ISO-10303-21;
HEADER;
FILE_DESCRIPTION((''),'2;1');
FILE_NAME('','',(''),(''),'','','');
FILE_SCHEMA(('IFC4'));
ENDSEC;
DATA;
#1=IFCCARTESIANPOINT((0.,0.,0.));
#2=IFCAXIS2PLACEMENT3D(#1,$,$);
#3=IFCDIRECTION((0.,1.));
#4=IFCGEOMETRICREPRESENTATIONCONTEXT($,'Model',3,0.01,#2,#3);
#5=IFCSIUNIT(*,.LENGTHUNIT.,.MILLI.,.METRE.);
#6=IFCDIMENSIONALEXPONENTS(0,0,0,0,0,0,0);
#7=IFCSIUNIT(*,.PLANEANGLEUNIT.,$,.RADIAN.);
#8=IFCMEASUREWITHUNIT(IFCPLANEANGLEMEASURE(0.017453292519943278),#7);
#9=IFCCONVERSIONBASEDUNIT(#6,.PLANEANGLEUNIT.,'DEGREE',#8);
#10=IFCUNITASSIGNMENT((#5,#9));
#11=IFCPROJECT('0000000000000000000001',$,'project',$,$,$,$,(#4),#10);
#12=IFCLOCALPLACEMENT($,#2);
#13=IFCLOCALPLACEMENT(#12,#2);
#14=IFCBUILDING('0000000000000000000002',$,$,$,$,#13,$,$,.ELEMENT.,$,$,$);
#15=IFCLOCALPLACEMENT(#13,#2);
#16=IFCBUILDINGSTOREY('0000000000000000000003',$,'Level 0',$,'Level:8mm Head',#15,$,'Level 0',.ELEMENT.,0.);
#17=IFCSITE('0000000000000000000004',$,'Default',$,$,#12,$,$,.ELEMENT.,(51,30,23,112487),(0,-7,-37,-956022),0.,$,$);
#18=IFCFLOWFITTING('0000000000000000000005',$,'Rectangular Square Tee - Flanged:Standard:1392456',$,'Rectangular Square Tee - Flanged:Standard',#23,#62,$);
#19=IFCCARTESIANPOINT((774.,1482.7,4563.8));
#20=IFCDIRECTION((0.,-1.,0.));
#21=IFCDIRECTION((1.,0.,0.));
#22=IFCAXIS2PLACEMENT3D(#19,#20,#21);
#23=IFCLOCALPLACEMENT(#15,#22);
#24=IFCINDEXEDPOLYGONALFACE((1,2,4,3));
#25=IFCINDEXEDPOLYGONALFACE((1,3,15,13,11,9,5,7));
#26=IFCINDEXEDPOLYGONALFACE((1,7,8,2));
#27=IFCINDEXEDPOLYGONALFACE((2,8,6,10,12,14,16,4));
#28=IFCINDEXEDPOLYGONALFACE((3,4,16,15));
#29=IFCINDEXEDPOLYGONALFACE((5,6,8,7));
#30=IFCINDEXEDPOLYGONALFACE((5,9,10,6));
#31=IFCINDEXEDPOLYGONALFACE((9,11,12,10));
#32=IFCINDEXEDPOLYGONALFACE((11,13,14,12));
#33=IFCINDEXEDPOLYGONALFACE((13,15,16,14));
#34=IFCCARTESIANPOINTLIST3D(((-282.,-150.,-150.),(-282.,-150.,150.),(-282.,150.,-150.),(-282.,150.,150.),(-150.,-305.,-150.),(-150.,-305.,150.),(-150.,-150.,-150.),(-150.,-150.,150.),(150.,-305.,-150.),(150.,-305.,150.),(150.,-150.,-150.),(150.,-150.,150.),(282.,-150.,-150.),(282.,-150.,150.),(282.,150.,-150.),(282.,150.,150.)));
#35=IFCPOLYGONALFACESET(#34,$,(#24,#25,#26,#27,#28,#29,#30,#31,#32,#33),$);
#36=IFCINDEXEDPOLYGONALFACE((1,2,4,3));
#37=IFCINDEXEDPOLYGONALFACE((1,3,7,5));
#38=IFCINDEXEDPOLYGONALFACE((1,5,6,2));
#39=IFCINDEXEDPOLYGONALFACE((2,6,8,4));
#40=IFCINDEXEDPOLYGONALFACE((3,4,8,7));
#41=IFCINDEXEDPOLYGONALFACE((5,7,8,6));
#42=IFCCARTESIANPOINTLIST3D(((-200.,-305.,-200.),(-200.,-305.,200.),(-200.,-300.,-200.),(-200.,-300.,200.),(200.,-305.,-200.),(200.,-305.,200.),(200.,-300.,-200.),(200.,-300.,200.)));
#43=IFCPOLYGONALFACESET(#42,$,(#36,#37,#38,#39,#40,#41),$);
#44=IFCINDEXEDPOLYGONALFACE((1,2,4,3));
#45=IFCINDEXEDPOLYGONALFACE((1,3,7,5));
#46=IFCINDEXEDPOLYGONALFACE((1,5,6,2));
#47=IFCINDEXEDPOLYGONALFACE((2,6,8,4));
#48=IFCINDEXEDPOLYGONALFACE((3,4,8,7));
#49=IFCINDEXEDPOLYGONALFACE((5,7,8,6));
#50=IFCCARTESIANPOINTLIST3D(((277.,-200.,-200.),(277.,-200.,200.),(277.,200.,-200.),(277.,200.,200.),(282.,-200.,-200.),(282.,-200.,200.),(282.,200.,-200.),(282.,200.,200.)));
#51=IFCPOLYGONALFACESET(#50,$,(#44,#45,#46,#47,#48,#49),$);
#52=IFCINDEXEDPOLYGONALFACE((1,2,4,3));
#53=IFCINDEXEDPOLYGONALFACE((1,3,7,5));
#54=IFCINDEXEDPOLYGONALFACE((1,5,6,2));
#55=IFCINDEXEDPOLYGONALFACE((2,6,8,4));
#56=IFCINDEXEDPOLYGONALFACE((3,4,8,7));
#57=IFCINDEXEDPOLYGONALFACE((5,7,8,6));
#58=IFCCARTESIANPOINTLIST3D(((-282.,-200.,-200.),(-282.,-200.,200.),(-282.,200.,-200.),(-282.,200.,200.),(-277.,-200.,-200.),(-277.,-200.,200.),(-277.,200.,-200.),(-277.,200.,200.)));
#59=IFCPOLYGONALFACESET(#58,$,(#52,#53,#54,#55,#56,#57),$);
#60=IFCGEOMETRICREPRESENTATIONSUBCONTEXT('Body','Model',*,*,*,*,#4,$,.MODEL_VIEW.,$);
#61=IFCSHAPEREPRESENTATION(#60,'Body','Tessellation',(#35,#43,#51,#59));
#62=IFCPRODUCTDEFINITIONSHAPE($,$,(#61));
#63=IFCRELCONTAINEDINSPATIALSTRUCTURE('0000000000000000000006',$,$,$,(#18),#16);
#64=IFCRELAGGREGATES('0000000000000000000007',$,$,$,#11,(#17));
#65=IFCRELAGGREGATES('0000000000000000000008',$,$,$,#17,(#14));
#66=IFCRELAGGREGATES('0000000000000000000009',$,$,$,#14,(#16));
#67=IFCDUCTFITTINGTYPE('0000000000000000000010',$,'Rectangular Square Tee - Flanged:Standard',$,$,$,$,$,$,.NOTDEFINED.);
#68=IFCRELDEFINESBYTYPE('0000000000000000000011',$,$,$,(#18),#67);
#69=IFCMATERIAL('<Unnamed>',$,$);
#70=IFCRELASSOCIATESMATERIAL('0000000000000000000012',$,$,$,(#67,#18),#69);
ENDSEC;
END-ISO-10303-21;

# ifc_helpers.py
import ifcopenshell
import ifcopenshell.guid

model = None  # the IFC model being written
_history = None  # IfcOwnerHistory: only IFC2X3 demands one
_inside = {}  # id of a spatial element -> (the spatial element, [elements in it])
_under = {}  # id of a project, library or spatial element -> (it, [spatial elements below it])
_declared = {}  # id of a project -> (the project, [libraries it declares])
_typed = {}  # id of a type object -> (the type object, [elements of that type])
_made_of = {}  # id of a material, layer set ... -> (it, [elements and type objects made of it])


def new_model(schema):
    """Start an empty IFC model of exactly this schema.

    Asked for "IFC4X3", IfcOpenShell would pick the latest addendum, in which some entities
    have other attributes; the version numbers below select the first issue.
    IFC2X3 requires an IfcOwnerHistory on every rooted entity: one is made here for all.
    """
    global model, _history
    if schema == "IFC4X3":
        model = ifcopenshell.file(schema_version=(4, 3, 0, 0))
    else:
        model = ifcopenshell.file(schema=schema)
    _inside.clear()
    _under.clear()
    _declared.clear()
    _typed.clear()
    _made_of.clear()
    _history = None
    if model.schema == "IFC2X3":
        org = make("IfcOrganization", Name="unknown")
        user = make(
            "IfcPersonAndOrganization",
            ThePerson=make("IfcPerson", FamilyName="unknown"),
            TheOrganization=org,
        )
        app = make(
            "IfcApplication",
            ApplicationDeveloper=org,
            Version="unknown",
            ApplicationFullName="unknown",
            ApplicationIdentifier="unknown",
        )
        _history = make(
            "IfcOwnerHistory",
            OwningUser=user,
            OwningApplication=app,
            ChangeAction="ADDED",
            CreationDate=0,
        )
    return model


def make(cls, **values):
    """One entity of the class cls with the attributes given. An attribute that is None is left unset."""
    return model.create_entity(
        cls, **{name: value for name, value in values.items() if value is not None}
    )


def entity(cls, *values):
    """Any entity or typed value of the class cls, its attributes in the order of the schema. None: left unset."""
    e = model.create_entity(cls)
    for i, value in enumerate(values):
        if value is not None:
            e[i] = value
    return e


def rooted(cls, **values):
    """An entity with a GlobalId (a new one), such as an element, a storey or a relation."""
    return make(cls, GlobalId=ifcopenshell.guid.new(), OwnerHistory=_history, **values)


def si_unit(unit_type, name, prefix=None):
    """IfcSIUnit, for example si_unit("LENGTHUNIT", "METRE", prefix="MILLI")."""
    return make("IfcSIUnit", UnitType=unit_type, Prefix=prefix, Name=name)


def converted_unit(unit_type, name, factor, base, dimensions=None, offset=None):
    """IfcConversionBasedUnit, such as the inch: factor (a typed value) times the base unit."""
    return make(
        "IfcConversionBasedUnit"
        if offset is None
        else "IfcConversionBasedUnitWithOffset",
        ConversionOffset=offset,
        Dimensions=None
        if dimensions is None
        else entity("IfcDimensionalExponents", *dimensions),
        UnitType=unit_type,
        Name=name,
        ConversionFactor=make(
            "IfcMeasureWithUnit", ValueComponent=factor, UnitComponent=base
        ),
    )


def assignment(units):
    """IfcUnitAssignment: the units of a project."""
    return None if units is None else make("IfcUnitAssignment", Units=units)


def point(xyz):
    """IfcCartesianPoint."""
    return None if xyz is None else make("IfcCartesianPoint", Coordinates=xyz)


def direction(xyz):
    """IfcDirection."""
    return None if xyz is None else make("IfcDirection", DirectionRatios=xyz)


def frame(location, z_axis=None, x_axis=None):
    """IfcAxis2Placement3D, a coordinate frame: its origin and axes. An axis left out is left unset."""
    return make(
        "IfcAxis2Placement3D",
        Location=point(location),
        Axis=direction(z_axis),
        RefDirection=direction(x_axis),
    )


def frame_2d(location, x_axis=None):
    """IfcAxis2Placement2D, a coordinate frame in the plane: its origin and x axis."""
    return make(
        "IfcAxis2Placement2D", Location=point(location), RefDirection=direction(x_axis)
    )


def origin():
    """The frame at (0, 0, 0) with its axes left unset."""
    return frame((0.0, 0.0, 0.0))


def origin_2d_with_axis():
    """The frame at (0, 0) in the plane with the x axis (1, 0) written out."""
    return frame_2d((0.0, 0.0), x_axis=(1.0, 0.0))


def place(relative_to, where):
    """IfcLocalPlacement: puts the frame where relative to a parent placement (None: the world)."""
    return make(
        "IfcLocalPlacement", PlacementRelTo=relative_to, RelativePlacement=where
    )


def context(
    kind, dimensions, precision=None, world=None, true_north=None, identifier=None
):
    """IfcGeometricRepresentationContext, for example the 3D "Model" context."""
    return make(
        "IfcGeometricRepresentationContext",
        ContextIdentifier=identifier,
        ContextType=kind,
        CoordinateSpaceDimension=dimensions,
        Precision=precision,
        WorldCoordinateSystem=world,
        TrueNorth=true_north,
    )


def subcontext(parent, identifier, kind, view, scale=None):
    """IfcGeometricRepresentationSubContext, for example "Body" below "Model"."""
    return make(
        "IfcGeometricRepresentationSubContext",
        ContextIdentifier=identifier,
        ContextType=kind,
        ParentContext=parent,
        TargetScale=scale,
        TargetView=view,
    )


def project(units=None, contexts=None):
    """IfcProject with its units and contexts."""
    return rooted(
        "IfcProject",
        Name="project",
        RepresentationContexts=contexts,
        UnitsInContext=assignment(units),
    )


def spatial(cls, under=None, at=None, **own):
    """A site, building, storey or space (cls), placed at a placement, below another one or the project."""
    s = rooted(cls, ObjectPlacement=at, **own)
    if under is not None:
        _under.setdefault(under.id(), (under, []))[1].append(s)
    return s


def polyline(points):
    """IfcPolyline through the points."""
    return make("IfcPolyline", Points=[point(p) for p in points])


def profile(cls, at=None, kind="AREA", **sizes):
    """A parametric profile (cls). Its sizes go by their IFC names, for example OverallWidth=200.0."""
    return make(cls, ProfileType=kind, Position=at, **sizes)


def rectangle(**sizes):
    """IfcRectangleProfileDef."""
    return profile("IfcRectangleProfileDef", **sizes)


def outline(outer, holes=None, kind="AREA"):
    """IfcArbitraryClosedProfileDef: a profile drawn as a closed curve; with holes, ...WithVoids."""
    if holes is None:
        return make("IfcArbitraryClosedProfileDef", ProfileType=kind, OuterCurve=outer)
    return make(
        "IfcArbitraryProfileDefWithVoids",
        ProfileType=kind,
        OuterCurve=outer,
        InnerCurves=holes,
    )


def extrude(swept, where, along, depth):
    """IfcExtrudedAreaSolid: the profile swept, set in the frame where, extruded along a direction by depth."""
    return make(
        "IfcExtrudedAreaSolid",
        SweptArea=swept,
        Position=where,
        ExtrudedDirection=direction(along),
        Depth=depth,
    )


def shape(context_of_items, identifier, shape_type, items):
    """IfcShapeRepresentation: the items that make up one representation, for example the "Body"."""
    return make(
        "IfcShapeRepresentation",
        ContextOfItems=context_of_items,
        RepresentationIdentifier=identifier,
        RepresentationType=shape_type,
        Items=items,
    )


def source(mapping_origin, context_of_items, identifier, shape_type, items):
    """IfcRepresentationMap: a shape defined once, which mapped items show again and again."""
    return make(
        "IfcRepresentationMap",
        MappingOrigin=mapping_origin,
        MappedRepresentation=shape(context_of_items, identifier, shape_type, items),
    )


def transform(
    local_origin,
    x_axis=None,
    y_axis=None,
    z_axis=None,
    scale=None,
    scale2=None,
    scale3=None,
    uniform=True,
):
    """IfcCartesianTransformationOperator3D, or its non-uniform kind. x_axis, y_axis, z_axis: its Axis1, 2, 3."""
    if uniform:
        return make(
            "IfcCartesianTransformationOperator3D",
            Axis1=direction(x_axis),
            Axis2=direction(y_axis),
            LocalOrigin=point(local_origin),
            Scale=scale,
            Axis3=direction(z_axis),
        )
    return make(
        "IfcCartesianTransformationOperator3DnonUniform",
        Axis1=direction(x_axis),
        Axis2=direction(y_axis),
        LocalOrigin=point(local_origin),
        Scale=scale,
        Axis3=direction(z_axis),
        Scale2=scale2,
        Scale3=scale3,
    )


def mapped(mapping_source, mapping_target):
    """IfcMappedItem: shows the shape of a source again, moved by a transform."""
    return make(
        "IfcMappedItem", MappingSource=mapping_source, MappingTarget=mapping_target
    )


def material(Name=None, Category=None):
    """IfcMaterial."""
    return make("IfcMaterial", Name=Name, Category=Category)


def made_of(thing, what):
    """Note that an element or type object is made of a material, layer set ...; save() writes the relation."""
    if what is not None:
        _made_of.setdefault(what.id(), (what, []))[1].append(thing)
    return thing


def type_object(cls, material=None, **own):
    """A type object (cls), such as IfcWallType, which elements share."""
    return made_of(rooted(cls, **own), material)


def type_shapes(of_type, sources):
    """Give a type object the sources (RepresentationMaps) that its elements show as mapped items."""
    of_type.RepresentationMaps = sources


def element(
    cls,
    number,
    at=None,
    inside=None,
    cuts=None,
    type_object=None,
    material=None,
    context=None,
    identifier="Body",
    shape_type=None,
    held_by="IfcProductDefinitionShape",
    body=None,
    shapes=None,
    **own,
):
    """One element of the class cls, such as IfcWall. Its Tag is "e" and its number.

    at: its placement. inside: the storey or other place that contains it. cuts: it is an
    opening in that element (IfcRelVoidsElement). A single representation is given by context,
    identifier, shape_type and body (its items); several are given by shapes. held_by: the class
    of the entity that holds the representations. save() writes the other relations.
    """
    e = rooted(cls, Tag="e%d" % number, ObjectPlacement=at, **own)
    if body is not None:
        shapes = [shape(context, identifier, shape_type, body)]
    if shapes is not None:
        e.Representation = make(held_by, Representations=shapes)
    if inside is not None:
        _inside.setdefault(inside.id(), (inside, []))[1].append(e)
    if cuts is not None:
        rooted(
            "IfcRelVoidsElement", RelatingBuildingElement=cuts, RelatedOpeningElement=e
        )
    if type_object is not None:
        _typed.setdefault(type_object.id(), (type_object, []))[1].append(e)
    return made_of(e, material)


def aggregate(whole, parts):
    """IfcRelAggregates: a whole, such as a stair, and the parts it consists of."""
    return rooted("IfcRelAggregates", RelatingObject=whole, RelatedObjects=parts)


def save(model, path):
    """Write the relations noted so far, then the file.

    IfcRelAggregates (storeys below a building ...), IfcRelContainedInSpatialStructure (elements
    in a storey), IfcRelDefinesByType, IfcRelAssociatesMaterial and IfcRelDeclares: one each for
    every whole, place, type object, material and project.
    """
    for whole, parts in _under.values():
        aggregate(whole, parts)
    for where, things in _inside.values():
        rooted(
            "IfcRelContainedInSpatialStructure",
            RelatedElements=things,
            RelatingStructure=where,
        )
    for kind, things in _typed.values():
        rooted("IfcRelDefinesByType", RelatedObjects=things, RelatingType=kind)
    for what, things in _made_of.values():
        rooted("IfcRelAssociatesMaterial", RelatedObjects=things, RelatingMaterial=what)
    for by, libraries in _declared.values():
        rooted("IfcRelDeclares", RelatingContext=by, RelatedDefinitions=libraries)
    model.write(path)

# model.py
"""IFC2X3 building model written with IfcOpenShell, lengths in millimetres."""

from ifc_helpers import new_model, entity, si_unit, converted_unit, direction, frame, frame_2d, origin, origin_2d_with_axis, place, context, subcontext, project, spatial, polyline, rectangle, outline, extrude, source, transform, mapped, material, type_object, type_shapes, element, save


model = new_model("IFC2X3")

# Units and contexts
model_context = context("Model", 3, precision=0.01, world=origin(), true_north=direction((0.0, 1.0)))
body_context = subcontext(model_context, "Body", "Model", "MODEL_VIEW")
ifc_project = project(units=[si_unit("LENGTHUNIT", "METRE", prefix="MILLI"), converted_unit("PLANEANGLEUNIT", "DEGREE", entity("IfcPlaneAngleMeasure", 0.017453292519943278), si_unit("PLANEANGLEUNIT", "RADIAN"), dimensions=[0, 0, 0, 0, 0, 0, 0])], contexts=[model_context])

# Site, building, storey
site_placement = place(None, origin())
site = spatial("IfcSite", under=ifc_project, at=site_placement, Name="Default", CompositionType="ELEMENT", RefLatitude=(51, 30, 23, 112487), RefLongitude=(0, -7, -37, -956022), RefElevation=0.0)
building_placement = place(site_placement, origin())
building = spatial("IfcBuilding", under=site, at=building_placement, CompositionType="ELEMENT")
storey_placement = place(building_placement, origin())
storey = spatial("IfcBuildingStorey", under=building, at=storey_placement, Name="Level 0", ObjectType="Level:8mm Head", LongName="Level 0", CompositionType="ELEMENT", Elevation=0.0)

# Shared definitions
ifc_material = material(Name="<Unnamed>")

# Flow fitting
duct_fitting_type_1 = type_object("IfcDuctFittingType", Name="Rectangular Square Tee - Flanged:Standard", PredefinedType="NOTDEFINED", material=ifc_material)
shared_shape_1 = source(origin(), body_context, "Body", "SweptSolid", [
    extrude(outline(polyline([(-282.0, 36.2), (-282.0, -263.8), (282.0, -263.7), (282.0, 36.3), (150.0, 36.3), (150.0, 191.2), (-150.0, 191.2), (-150.0, 36.2), (-282.0, 36.2)])), frame((0.0, -113.8, -150.0), z_axis=(0.0, 0.0, -1.0), x_axis=(1.0, 0.0, 0.0)), (0.0, 0.0, -1.0), 300.0),
    extrude(rectangle(XDim=5.0, YDim=400.0, at=frame_2d((0.0, 0.0), x_axis=(1.0, 0.0))), frame((0.0, -302.5, -200.0), z_axis=(0.0, 0.0, 1.0), x_axis=(0.0, -1.0, 0.0)), (0.0, 0.0, 1.0), 400.0),
    extrude(rectangle(XDim=5.0, YDim=400.0, at=origin_2d_with_axis()), frame((279.5, 0.0, -200.0)), (0.0, 0.0, 1.0), 400.0),
    extrude(rectangle(XDim=5.0, YDim=400.0, at=origin_2d_with_axis()), frame((-279.5, 0.0, -200.0)), (0.0, 0.0, 1.0), 400.0),
])
type_shapes(duct_fitting_type_1, [shared_shape_1])
flow_fitting_placement = place(storey_placement, frame((774.0, 1482.7, 4563.8), z_axis=(0.0, -1.0, 0.0), x_axis=(1.0, 0.0, 0.0)))
element("IfcFlowFitting", 1, at=flow_fitting_placement, inside=storey, type_object=duct_fitting_type_1, material=ifc_material, Name="Rectangular Square Tee - Flanged:Standard:1392456", ObjectType="Rectangular Square Tee - Flanged:Standard", context=body_context, shape_type="MappedRepresentation", body=[
    mapped(shared_shape_1, transform((0.0, 0.0, 0.0), scale=1.0)),
])

save(model, "model.ifc")
